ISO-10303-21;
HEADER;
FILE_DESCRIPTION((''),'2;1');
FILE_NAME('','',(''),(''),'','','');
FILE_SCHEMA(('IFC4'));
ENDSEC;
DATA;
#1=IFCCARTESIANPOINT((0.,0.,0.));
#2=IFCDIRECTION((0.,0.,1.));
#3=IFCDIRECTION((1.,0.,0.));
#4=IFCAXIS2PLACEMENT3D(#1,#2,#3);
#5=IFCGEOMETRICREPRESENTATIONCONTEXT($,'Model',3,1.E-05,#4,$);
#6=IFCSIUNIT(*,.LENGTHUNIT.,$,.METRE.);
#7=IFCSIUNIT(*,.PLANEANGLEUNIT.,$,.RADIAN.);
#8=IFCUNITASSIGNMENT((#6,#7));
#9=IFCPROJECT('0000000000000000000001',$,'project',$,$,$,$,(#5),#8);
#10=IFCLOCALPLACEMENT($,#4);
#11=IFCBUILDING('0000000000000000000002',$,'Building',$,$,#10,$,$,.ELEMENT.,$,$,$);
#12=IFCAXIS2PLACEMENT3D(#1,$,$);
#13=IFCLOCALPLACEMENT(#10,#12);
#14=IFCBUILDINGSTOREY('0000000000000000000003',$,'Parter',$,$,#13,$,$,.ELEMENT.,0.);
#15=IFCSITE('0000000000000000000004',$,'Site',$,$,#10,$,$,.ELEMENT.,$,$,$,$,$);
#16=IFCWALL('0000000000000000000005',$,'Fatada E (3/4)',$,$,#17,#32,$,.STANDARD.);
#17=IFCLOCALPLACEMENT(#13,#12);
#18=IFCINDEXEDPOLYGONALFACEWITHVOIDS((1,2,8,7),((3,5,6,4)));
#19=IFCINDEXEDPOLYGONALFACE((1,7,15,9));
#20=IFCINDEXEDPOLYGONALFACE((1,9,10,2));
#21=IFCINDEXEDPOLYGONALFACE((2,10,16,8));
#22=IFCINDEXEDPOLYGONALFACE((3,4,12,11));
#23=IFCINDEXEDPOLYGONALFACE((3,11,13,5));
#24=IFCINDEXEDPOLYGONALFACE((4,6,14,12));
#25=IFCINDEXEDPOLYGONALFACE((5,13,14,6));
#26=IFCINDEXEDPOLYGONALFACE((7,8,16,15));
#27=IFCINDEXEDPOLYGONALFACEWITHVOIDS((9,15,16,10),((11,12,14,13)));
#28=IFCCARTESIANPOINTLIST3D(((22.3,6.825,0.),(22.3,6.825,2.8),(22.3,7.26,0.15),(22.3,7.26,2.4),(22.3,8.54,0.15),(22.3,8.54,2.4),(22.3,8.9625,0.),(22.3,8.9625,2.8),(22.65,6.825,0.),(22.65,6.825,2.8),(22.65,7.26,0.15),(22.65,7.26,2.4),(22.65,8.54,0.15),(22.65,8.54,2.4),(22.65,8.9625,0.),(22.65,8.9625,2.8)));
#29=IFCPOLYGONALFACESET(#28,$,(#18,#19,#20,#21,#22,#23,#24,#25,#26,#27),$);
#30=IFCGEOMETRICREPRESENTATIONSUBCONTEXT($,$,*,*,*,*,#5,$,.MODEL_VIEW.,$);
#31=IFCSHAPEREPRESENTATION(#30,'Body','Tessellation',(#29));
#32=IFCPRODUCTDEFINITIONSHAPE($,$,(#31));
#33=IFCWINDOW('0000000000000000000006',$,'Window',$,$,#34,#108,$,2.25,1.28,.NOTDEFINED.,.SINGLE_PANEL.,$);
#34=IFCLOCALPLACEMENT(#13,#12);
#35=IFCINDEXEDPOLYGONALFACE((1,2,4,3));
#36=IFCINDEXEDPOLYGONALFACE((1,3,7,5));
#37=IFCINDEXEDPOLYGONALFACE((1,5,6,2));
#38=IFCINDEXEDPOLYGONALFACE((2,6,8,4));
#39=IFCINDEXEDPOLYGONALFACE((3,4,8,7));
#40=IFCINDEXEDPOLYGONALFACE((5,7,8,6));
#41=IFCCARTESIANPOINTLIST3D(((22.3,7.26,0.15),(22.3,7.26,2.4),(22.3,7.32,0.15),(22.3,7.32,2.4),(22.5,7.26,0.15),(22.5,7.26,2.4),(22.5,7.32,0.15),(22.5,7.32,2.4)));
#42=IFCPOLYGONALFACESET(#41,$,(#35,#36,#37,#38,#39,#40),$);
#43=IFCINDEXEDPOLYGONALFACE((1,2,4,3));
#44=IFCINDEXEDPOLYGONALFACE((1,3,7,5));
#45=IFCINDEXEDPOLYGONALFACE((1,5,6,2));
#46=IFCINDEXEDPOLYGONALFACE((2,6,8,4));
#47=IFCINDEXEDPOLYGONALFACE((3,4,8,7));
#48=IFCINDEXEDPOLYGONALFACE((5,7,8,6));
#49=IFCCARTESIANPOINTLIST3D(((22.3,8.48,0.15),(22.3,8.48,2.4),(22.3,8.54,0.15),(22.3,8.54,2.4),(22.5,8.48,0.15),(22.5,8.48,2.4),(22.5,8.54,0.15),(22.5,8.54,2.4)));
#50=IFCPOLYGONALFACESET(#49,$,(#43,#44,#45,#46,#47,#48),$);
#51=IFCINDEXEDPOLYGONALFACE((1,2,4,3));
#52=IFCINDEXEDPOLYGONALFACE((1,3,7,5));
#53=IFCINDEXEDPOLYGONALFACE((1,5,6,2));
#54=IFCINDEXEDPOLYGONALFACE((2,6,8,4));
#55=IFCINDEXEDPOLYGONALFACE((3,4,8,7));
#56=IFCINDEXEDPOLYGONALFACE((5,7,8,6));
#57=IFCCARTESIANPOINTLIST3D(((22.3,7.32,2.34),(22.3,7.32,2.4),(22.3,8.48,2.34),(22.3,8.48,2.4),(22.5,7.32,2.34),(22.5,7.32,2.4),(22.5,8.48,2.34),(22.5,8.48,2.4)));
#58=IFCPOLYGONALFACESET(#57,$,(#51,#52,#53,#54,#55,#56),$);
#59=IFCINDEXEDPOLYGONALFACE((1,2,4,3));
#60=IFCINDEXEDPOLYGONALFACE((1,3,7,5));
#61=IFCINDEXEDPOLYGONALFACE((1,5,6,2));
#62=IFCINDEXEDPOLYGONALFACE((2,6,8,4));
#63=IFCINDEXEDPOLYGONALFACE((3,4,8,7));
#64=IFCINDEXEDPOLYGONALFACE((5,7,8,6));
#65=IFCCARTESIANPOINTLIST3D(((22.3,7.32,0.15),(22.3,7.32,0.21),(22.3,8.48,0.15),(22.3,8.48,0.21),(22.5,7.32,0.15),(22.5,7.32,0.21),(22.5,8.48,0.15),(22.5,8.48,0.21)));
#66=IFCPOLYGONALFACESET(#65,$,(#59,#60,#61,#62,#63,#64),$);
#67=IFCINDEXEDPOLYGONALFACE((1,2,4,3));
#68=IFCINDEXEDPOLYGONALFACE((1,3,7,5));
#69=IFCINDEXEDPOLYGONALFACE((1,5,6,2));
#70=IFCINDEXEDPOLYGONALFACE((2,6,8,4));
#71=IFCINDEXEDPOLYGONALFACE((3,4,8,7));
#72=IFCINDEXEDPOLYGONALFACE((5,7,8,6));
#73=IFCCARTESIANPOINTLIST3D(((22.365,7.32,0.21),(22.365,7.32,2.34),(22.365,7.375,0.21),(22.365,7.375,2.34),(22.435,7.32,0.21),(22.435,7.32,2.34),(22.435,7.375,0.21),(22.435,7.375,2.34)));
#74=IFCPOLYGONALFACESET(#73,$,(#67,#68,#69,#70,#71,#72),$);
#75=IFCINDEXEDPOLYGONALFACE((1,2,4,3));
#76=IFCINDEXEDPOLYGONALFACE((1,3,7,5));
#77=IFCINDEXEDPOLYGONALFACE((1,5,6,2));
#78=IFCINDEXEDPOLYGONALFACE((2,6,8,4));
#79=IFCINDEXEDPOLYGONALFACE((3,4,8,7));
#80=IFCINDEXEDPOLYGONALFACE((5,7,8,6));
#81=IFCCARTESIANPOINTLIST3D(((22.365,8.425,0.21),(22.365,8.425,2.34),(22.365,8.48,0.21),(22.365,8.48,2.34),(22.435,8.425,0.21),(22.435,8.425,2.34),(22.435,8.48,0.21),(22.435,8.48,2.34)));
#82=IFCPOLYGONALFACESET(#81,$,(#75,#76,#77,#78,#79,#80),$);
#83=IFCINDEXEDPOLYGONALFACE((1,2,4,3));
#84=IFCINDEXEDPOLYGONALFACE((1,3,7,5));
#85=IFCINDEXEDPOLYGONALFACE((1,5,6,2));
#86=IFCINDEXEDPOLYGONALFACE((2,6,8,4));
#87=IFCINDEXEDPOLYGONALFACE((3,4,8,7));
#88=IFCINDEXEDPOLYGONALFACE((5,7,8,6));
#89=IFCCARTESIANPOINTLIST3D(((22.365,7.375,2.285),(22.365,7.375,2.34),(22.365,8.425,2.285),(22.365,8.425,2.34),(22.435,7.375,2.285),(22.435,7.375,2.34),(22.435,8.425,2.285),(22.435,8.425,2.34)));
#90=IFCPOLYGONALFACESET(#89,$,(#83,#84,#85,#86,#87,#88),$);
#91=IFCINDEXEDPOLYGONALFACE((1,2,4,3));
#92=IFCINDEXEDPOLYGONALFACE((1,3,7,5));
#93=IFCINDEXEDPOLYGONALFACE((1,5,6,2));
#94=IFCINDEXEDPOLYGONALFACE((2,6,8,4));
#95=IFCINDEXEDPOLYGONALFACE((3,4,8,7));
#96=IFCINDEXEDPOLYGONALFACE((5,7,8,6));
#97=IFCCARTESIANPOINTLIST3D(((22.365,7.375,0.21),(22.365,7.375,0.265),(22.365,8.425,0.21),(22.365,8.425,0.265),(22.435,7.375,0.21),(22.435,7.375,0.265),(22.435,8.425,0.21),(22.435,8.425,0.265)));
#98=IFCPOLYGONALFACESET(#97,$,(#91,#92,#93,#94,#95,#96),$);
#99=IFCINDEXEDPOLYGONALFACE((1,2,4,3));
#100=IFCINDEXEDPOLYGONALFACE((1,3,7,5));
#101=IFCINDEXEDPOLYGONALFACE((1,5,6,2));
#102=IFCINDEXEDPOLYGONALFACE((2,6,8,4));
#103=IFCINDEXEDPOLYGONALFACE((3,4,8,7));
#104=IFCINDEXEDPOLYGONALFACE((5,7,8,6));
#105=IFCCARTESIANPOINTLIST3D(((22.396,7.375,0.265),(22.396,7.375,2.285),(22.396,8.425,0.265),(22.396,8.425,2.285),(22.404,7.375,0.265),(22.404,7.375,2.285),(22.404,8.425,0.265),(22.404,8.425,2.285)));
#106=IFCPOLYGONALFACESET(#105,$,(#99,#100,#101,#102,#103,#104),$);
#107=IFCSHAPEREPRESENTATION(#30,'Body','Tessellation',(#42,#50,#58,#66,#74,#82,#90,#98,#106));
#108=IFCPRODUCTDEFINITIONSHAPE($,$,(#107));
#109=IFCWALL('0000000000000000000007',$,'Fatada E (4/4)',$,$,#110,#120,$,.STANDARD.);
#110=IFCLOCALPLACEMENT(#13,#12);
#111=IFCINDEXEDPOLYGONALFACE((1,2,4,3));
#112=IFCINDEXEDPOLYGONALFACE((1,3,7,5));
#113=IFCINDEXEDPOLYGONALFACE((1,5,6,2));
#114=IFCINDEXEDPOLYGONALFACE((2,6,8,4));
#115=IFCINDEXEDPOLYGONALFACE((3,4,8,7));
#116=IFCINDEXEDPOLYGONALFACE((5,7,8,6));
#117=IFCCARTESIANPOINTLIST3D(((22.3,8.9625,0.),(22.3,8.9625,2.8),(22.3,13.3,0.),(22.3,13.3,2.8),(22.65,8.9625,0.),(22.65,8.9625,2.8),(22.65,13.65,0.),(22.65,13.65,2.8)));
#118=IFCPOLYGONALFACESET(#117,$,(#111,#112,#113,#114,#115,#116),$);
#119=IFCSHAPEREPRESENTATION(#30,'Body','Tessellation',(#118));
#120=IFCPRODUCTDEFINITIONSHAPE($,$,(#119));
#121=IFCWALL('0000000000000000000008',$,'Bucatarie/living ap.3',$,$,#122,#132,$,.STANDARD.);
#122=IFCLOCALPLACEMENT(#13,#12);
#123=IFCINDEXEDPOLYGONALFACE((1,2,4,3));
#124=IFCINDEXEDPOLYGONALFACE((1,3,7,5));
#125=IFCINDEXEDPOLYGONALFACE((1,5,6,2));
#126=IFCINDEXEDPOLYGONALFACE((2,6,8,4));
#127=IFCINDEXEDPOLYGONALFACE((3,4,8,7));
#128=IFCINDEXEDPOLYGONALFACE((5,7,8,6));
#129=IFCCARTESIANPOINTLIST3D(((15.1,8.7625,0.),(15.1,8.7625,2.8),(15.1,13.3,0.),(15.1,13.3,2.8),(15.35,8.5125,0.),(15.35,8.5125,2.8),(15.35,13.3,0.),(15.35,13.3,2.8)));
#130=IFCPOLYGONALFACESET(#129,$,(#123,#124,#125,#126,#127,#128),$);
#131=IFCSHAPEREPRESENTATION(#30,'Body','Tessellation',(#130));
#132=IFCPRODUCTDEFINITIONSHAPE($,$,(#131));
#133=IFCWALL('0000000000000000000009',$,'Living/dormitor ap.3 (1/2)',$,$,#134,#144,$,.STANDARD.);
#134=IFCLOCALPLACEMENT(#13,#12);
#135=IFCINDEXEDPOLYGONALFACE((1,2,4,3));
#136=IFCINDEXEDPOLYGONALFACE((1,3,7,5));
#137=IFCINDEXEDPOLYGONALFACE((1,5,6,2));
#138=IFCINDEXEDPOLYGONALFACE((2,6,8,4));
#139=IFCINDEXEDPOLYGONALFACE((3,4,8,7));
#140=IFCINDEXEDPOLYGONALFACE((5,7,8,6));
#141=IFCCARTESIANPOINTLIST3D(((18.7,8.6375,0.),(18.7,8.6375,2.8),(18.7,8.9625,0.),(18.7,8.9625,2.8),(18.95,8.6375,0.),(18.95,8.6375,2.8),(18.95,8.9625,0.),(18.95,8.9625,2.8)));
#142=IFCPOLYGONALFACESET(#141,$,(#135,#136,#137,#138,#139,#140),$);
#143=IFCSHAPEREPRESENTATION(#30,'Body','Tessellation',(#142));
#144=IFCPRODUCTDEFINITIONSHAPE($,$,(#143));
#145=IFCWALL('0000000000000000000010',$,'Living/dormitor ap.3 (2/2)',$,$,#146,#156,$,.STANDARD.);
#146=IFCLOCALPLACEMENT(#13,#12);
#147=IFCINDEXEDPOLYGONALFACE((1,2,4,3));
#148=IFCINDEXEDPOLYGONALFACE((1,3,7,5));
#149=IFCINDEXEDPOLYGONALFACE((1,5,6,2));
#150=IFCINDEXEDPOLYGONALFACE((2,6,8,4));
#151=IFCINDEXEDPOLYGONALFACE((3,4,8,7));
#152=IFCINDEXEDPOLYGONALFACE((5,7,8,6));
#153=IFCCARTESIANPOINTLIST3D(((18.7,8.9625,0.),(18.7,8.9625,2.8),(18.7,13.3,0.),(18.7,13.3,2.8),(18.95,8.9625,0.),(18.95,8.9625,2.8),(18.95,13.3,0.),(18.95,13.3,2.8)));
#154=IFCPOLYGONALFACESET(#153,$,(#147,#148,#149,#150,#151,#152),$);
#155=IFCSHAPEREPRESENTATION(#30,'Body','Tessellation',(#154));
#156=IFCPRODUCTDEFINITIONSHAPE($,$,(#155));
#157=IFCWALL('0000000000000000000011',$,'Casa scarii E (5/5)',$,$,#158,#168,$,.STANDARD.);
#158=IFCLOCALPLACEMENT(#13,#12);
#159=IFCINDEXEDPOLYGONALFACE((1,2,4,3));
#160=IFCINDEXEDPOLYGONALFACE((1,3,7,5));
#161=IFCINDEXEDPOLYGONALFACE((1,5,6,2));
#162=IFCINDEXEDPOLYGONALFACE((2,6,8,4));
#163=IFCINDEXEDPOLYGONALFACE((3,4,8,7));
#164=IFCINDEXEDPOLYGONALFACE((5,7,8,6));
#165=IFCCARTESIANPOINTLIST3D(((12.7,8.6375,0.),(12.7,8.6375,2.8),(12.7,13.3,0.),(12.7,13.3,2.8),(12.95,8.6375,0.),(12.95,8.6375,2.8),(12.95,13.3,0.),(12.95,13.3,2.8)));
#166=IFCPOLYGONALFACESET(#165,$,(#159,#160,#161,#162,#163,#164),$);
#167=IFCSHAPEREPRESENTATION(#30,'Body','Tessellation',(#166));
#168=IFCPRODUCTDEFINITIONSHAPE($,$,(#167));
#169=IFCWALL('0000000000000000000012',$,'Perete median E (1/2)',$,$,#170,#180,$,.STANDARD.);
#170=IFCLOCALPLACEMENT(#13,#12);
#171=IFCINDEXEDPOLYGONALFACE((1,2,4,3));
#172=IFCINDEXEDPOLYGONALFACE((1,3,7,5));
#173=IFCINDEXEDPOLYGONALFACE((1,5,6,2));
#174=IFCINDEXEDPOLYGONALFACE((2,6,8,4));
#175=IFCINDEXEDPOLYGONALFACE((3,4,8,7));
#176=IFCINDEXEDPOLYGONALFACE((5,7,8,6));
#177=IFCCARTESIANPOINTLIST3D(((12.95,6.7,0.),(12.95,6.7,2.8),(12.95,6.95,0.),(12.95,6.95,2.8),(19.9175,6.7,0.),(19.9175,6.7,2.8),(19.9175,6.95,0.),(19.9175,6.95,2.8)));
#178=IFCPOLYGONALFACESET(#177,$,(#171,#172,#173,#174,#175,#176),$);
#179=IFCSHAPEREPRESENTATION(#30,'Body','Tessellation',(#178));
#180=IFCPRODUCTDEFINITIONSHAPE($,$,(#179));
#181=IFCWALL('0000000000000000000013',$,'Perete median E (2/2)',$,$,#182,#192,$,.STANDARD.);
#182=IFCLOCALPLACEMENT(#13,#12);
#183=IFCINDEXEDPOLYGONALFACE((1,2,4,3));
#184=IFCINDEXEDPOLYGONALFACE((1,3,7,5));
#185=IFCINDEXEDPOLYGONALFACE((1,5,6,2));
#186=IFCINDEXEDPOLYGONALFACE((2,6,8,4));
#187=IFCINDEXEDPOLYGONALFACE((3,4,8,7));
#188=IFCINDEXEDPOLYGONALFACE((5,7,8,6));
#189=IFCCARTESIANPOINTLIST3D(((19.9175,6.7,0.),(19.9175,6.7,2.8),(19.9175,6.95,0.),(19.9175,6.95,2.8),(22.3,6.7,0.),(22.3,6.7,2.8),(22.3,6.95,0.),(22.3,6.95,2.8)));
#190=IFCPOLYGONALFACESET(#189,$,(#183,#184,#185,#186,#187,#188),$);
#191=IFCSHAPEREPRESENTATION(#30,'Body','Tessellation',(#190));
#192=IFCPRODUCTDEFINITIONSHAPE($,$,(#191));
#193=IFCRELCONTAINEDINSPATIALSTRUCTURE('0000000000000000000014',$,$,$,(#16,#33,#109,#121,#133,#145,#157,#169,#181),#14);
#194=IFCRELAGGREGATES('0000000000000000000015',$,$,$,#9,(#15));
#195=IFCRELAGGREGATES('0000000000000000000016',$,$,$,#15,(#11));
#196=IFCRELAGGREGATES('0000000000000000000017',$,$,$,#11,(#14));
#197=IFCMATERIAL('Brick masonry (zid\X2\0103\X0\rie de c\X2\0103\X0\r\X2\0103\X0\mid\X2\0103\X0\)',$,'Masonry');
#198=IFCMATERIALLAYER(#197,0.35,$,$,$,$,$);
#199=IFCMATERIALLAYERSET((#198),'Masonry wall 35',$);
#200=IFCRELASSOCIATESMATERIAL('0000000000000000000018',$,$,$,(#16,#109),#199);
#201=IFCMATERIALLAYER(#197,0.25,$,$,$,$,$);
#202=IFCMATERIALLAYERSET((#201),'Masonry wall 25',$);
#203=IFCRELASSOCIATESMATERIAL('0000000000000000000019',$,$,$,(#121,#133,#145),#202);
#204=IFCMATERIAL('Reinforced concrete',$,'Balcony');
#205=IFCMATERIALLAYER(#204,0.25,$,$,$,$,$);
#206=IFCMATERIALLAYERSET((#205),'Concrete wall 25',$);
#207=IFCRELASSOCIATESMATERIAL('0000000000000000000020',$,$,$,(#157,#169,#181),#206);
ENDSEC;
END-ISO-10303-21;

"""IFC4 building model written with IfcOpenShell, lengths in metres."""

from ifc_helpers import new_model, si_unit, frame, frame_2d, origin, origin_with_axes, origin_2d, place, context, subcontext, project, spatial, rectangle, extrude, clip, halfspace, material, layer, layer_set, layer_usage, element, fill, save


model = new_model("IFC4")

# Units and contexts
model_context = context("Model", 3, precision=1e-05, world=origin_with_axes())
sub_context = subcontext(model_context, None, None, "MODEL_VIEW")
ifc_project = project(units=[si_unit("LENGTHUNIT", "METRE"), si_unit("PLANEANGLEUNIT", "RADIAN")], contexts=[model_context])

# Site, building, storey
placement = place(None, origin_with_axes())
site = spatial("IfcSite", under=ifc_project, at=placement, Name="Site", CompositionType="ELEMENT")
building = spatial("IfcBuilding", under=site, at=placement, Name="Building", CompositionType="ELEMENT")
storey_placement = place(placement, origin())
storey = spatial("IfcBuildingStorey", under=building, at=storey_placement, Name="Parter", CompositionType="ELEMENT", Elevation=0.0)

# Wall, opening, window
ifc_material_1 = material(Name="Brick masonry (zidărie de cărămidă)", Category="Masonry")
ifc_layer_1 = layer(ifc_material_1, 0.35)
ifc_layer_set_1 = layer_set([ifc_layer_1], Name="Masonry wall 35")
ifc_layer_usage_1 = layer_usage(ifc_layer_set_1, "AXIS2", "POSITIVE", -0.175)
wall_1_placement = place(storey_placement, frame((22.475, 6.825, 0.0), x_axis=(0.0, 1.0, 0.0)))
wall_1 = element("IfcWall", 1, at=wall_1_placement, inside=storey, material=ifc_layer_usage_1, Name="Fatada E (3/4)", PredefinedType="STANDARD", context=sub_context, shape_type="SweptSolid", body=[
    extrude(rectangle(XDim=2.1375, YDim=0.35, at=frame_2d((1.0688, 0.0))), origin(), (0.0, 0.0, 1.0), 2.8),
])
opening_1_placement = place(wall_1_placement, frame((1.075, 0.225, 0.15), z_axis=(0.0, -1.0, 0.0), x_axis=(1.0, 0.0, 0.0)))
opening_1 = element("IfcOpeningElement", 2, at=opening_1_placement, cuts=wall_1, PredefinedType="OPENING", context=sub_context, shape_type="SweptSolid", body=[
    extrude(rectangle(XDim=1.28, YDim=2.25, at=frame_2d((0.0, 1.125))), origin(), (0.0, 0.0, 1.0), 0.45),
])
window_1_placement = place(wall_1_placement, frame((1.075, 0.175, 0.15), z_axis=(0.0, -1.0, 0.0), x_axis=(1.0, 0.0, 0.0)))
window_1 = element("IfcWindow", 3, at=window_1_placement, inside=storey, Name="Window", OverallHeight=2.25, OverallWidth=1.28, PartitioningType="SINGLE_PANEL", PredefinedType="NOTDEFINED", context=sub_context, shape_type="SweptSolid", body=[
    extrude(rectangle(XDim=0.06, YDim=2.25, at=origin_2d()), frame((-0.61, 1.125, 0.0)), (0.0, 0.0, 1.0), 0.2),
    extrude(rectangle(XDim=0.06, YDim=2.25, at=origin_2d()), frame((0.61, 1.125, 0.0)), (0.0, 0.0, 1.0), 0.2),
    extrude(rectangle(XDim=1.16, YDim=0.06, at=origin_2d()), frame((0.0, 2.22, 0.0)), (0.0, 0.0, 1.0), 0.2),
    extrude(rectangle(XDim=1.16, YDim=0.06, at=origin_2d()), frame((0.0, 0.03, 0.0)), (0.0, 0.0, 1.0), 0.2),
    extrude(rectangle(XDim=0.055, YDim=2.13, at=origin_2d()), frame((-0.5525, 1.125, 0.065)), (0.0, 0.0, 1.0), 0.07),
    extrude(rectangle(XDim=0.055, YDim=2.13, at=origin_2d()), frame((0.5525, 1.125, 0.065)), (0.0, 0.0, 1.0), 0.07),
    extrude(rectangle(XDim=1.05, YDim=0.055, at=origin_2d()), frame((0.0, 2.1625, 0.065)), (0.0, 0.0, 1.0), 0.07),
    extrude(rectangle(XDim=1.05, YDim=0.055, at=origin_2d()), frame((0.0, 0.0875, 0.065)), (0.0, 0.0, 1.0), 0.07),
    extrude(rectangle(XDim=1.05, YDim=2.02, at=origin_2d()), frame((0.0, 1.125, 0.096)), (0.0, 0.0, 1.0), 0.008),
])
fill(opening_1, window_1)

# Walls
wall_2_placement = place(storey_placement, frame((22.475, 8.9625, 0.0), x_axis=(0.0, 1.0, 0.0)))
element("IfcWall", 4, at=wall_2_placement, inside=storey, material=ifc_layer_usage_1, Name="Fatada E (4/4)", PredefinedType="STANDARD", context=sub_context, shape_type="CSG", body=[
    clip(extrude(rectangle(XDim=4.6875, YDim=0.35, at=frame_2d((2.3438, 0.0))), origin(), (0.0, 0.0, 1.0), 2.8), halfspace(frame((4.5125, 0.0, 0.0), z_axis=(0.707107, 0.707107, 0.0)), False)),
])
ifc_layer_2 = layer(ifc_material_1, 0.25)
ifc_layer_set_2 = layer_set([ifc_layer_2], Name="Masonry wall 25")
ifc_layer_usage_2 = layer_usage(ifc_layer_set_2, "AXIS2", "POSITIVE", -0.125)
wall_3_placement = place(storey_placement, frame((15.225, 8.5125, 0.0), x_axis=(0.0, 1.0, 0.0)))
element("IfcWall", 5, at=wall_3_placement, inside=storey, material=ifc_layer_usage_2, Name="Bucatarie/living ap.3", PredefinedType="STANDARD", context=sub_context, shape_type="CSG", body=[
    clip(extrude(rectangle(XDim=4.7875, YDim=0.25, at=frame_2d((2.3938, 0.0))), origin(), (0.0, 0.0, 1.0), 2.8), halfspace(frame((0.125, 0.0, 0.0), z_axis=(-0.707107, 0.707107, 0.0)), False)),
])
wall_4_placement = place(storey_placement, frame((18.825, 8.6375, 0.0), x_axis=(0.0, 1.0, 0.0)))
element("IfcWall", 6, at=wall_4_placement, inside=storey, material=ifc_layer_usage_2, Name="Living/dormitor ap.3 (1/2)", PredefinedType="STANDARD", context=sub_context, shape_type="SweptSolid", body=[
    extrude(rectangle(XDim=0.325, YDim=0.25, at=frame_2d((0.1625, 0.0))), origin(), (0.0, 0.0, 1.0), 2.8),
])
wall_5_placement = place(storey_placement, frame((18.825, 8.9625, 0.0), x_axis=(0.0, 1.0, 0.0)))
element("IfcWall", 7, at=wall_5_placement, inside=storey, material=ifc_layer_usage_2, Name="Living/dormitor ap.3 (2/2)", PredefinedType="STANDARD", context=sub_context, shape_type="SweptSolid", body=[
    extrude(rectangle(XDim=4.3375, YDim=0.25, at=frame_2d((2.1688, 0.0))), origin(), (0.0, 0.0, 1.0), 2.8),
])
ifc_material_2 = material(Name="Reinforced concrete", Category="Balcony")
ifc_layer_3 = layer(ifc_material_2, 0.25)
ifc_layer_set_3 = layer_set([ifc_layer_3], Name="Concrete wall 25")
ifc_layer_usage_3 = layer_usage(ifc_layer_set_3, "AXIS2", "POSITIVE", -0.125)
wall_6_placement = place(storey_placement, frame((12.825, 8.6375, 0.0), x_axis=(0.0, 1.0, 0.0)))
element("IfcWall", 8, at=wall_6_placement, inside=storey, material=ifc_layer_usage_3, Name="Casa scarii E (5/5)", PredefinedType="STANDARD", context=sub_context, shape_type="SweptSolid", body=[
    extrude(rectangle(XDim=4.6625, YDim=0.25, at=frame_2d((2.3312, 0.0))), origin(), (0.0, 0.0, 1.0), 2.8),
])
wall_7_placement = place(storey_placement, frame((12.95, 6.825, 0.0), x_axis=(1.0, 0.0, 0.0)))
element("IfcWall", 9, at=wall_7_placement, inside=storey, material=ifc_layer_usage_3, Name="Perete median E (1/2)", PredefinedType="STANDARD", context=sub_context, shape_type="SweptSolid", body=[
    extrude(rectangle(XDim=6.9675, YDim=0.25, at=frame_2d((3.4837, 0.0))), origin(), (0.0, 0.0, 1.0), 2.8),
])
wall_8_placement = place(storey_placement, frame((19.9175, 6.825, 0.0), x_axis=(1.0, 0.0, 0.0)))
element("IfcWall", 10, at=wall_8_placement, inside=storey, material=ifc_layer_usage_3, Name="Perete median E (2/2)", PredefinedType="STANDARD", context=sub_context, shape_type="SweptSolid", body=[
    extrude(rectangle(XDim=2.3825, YDim=0.25, at=frame_2d((1.1913, 0.0))), origin(), (0.0, 0.0, 1.0), 2.8),
])

save(model, "model.ifc")
